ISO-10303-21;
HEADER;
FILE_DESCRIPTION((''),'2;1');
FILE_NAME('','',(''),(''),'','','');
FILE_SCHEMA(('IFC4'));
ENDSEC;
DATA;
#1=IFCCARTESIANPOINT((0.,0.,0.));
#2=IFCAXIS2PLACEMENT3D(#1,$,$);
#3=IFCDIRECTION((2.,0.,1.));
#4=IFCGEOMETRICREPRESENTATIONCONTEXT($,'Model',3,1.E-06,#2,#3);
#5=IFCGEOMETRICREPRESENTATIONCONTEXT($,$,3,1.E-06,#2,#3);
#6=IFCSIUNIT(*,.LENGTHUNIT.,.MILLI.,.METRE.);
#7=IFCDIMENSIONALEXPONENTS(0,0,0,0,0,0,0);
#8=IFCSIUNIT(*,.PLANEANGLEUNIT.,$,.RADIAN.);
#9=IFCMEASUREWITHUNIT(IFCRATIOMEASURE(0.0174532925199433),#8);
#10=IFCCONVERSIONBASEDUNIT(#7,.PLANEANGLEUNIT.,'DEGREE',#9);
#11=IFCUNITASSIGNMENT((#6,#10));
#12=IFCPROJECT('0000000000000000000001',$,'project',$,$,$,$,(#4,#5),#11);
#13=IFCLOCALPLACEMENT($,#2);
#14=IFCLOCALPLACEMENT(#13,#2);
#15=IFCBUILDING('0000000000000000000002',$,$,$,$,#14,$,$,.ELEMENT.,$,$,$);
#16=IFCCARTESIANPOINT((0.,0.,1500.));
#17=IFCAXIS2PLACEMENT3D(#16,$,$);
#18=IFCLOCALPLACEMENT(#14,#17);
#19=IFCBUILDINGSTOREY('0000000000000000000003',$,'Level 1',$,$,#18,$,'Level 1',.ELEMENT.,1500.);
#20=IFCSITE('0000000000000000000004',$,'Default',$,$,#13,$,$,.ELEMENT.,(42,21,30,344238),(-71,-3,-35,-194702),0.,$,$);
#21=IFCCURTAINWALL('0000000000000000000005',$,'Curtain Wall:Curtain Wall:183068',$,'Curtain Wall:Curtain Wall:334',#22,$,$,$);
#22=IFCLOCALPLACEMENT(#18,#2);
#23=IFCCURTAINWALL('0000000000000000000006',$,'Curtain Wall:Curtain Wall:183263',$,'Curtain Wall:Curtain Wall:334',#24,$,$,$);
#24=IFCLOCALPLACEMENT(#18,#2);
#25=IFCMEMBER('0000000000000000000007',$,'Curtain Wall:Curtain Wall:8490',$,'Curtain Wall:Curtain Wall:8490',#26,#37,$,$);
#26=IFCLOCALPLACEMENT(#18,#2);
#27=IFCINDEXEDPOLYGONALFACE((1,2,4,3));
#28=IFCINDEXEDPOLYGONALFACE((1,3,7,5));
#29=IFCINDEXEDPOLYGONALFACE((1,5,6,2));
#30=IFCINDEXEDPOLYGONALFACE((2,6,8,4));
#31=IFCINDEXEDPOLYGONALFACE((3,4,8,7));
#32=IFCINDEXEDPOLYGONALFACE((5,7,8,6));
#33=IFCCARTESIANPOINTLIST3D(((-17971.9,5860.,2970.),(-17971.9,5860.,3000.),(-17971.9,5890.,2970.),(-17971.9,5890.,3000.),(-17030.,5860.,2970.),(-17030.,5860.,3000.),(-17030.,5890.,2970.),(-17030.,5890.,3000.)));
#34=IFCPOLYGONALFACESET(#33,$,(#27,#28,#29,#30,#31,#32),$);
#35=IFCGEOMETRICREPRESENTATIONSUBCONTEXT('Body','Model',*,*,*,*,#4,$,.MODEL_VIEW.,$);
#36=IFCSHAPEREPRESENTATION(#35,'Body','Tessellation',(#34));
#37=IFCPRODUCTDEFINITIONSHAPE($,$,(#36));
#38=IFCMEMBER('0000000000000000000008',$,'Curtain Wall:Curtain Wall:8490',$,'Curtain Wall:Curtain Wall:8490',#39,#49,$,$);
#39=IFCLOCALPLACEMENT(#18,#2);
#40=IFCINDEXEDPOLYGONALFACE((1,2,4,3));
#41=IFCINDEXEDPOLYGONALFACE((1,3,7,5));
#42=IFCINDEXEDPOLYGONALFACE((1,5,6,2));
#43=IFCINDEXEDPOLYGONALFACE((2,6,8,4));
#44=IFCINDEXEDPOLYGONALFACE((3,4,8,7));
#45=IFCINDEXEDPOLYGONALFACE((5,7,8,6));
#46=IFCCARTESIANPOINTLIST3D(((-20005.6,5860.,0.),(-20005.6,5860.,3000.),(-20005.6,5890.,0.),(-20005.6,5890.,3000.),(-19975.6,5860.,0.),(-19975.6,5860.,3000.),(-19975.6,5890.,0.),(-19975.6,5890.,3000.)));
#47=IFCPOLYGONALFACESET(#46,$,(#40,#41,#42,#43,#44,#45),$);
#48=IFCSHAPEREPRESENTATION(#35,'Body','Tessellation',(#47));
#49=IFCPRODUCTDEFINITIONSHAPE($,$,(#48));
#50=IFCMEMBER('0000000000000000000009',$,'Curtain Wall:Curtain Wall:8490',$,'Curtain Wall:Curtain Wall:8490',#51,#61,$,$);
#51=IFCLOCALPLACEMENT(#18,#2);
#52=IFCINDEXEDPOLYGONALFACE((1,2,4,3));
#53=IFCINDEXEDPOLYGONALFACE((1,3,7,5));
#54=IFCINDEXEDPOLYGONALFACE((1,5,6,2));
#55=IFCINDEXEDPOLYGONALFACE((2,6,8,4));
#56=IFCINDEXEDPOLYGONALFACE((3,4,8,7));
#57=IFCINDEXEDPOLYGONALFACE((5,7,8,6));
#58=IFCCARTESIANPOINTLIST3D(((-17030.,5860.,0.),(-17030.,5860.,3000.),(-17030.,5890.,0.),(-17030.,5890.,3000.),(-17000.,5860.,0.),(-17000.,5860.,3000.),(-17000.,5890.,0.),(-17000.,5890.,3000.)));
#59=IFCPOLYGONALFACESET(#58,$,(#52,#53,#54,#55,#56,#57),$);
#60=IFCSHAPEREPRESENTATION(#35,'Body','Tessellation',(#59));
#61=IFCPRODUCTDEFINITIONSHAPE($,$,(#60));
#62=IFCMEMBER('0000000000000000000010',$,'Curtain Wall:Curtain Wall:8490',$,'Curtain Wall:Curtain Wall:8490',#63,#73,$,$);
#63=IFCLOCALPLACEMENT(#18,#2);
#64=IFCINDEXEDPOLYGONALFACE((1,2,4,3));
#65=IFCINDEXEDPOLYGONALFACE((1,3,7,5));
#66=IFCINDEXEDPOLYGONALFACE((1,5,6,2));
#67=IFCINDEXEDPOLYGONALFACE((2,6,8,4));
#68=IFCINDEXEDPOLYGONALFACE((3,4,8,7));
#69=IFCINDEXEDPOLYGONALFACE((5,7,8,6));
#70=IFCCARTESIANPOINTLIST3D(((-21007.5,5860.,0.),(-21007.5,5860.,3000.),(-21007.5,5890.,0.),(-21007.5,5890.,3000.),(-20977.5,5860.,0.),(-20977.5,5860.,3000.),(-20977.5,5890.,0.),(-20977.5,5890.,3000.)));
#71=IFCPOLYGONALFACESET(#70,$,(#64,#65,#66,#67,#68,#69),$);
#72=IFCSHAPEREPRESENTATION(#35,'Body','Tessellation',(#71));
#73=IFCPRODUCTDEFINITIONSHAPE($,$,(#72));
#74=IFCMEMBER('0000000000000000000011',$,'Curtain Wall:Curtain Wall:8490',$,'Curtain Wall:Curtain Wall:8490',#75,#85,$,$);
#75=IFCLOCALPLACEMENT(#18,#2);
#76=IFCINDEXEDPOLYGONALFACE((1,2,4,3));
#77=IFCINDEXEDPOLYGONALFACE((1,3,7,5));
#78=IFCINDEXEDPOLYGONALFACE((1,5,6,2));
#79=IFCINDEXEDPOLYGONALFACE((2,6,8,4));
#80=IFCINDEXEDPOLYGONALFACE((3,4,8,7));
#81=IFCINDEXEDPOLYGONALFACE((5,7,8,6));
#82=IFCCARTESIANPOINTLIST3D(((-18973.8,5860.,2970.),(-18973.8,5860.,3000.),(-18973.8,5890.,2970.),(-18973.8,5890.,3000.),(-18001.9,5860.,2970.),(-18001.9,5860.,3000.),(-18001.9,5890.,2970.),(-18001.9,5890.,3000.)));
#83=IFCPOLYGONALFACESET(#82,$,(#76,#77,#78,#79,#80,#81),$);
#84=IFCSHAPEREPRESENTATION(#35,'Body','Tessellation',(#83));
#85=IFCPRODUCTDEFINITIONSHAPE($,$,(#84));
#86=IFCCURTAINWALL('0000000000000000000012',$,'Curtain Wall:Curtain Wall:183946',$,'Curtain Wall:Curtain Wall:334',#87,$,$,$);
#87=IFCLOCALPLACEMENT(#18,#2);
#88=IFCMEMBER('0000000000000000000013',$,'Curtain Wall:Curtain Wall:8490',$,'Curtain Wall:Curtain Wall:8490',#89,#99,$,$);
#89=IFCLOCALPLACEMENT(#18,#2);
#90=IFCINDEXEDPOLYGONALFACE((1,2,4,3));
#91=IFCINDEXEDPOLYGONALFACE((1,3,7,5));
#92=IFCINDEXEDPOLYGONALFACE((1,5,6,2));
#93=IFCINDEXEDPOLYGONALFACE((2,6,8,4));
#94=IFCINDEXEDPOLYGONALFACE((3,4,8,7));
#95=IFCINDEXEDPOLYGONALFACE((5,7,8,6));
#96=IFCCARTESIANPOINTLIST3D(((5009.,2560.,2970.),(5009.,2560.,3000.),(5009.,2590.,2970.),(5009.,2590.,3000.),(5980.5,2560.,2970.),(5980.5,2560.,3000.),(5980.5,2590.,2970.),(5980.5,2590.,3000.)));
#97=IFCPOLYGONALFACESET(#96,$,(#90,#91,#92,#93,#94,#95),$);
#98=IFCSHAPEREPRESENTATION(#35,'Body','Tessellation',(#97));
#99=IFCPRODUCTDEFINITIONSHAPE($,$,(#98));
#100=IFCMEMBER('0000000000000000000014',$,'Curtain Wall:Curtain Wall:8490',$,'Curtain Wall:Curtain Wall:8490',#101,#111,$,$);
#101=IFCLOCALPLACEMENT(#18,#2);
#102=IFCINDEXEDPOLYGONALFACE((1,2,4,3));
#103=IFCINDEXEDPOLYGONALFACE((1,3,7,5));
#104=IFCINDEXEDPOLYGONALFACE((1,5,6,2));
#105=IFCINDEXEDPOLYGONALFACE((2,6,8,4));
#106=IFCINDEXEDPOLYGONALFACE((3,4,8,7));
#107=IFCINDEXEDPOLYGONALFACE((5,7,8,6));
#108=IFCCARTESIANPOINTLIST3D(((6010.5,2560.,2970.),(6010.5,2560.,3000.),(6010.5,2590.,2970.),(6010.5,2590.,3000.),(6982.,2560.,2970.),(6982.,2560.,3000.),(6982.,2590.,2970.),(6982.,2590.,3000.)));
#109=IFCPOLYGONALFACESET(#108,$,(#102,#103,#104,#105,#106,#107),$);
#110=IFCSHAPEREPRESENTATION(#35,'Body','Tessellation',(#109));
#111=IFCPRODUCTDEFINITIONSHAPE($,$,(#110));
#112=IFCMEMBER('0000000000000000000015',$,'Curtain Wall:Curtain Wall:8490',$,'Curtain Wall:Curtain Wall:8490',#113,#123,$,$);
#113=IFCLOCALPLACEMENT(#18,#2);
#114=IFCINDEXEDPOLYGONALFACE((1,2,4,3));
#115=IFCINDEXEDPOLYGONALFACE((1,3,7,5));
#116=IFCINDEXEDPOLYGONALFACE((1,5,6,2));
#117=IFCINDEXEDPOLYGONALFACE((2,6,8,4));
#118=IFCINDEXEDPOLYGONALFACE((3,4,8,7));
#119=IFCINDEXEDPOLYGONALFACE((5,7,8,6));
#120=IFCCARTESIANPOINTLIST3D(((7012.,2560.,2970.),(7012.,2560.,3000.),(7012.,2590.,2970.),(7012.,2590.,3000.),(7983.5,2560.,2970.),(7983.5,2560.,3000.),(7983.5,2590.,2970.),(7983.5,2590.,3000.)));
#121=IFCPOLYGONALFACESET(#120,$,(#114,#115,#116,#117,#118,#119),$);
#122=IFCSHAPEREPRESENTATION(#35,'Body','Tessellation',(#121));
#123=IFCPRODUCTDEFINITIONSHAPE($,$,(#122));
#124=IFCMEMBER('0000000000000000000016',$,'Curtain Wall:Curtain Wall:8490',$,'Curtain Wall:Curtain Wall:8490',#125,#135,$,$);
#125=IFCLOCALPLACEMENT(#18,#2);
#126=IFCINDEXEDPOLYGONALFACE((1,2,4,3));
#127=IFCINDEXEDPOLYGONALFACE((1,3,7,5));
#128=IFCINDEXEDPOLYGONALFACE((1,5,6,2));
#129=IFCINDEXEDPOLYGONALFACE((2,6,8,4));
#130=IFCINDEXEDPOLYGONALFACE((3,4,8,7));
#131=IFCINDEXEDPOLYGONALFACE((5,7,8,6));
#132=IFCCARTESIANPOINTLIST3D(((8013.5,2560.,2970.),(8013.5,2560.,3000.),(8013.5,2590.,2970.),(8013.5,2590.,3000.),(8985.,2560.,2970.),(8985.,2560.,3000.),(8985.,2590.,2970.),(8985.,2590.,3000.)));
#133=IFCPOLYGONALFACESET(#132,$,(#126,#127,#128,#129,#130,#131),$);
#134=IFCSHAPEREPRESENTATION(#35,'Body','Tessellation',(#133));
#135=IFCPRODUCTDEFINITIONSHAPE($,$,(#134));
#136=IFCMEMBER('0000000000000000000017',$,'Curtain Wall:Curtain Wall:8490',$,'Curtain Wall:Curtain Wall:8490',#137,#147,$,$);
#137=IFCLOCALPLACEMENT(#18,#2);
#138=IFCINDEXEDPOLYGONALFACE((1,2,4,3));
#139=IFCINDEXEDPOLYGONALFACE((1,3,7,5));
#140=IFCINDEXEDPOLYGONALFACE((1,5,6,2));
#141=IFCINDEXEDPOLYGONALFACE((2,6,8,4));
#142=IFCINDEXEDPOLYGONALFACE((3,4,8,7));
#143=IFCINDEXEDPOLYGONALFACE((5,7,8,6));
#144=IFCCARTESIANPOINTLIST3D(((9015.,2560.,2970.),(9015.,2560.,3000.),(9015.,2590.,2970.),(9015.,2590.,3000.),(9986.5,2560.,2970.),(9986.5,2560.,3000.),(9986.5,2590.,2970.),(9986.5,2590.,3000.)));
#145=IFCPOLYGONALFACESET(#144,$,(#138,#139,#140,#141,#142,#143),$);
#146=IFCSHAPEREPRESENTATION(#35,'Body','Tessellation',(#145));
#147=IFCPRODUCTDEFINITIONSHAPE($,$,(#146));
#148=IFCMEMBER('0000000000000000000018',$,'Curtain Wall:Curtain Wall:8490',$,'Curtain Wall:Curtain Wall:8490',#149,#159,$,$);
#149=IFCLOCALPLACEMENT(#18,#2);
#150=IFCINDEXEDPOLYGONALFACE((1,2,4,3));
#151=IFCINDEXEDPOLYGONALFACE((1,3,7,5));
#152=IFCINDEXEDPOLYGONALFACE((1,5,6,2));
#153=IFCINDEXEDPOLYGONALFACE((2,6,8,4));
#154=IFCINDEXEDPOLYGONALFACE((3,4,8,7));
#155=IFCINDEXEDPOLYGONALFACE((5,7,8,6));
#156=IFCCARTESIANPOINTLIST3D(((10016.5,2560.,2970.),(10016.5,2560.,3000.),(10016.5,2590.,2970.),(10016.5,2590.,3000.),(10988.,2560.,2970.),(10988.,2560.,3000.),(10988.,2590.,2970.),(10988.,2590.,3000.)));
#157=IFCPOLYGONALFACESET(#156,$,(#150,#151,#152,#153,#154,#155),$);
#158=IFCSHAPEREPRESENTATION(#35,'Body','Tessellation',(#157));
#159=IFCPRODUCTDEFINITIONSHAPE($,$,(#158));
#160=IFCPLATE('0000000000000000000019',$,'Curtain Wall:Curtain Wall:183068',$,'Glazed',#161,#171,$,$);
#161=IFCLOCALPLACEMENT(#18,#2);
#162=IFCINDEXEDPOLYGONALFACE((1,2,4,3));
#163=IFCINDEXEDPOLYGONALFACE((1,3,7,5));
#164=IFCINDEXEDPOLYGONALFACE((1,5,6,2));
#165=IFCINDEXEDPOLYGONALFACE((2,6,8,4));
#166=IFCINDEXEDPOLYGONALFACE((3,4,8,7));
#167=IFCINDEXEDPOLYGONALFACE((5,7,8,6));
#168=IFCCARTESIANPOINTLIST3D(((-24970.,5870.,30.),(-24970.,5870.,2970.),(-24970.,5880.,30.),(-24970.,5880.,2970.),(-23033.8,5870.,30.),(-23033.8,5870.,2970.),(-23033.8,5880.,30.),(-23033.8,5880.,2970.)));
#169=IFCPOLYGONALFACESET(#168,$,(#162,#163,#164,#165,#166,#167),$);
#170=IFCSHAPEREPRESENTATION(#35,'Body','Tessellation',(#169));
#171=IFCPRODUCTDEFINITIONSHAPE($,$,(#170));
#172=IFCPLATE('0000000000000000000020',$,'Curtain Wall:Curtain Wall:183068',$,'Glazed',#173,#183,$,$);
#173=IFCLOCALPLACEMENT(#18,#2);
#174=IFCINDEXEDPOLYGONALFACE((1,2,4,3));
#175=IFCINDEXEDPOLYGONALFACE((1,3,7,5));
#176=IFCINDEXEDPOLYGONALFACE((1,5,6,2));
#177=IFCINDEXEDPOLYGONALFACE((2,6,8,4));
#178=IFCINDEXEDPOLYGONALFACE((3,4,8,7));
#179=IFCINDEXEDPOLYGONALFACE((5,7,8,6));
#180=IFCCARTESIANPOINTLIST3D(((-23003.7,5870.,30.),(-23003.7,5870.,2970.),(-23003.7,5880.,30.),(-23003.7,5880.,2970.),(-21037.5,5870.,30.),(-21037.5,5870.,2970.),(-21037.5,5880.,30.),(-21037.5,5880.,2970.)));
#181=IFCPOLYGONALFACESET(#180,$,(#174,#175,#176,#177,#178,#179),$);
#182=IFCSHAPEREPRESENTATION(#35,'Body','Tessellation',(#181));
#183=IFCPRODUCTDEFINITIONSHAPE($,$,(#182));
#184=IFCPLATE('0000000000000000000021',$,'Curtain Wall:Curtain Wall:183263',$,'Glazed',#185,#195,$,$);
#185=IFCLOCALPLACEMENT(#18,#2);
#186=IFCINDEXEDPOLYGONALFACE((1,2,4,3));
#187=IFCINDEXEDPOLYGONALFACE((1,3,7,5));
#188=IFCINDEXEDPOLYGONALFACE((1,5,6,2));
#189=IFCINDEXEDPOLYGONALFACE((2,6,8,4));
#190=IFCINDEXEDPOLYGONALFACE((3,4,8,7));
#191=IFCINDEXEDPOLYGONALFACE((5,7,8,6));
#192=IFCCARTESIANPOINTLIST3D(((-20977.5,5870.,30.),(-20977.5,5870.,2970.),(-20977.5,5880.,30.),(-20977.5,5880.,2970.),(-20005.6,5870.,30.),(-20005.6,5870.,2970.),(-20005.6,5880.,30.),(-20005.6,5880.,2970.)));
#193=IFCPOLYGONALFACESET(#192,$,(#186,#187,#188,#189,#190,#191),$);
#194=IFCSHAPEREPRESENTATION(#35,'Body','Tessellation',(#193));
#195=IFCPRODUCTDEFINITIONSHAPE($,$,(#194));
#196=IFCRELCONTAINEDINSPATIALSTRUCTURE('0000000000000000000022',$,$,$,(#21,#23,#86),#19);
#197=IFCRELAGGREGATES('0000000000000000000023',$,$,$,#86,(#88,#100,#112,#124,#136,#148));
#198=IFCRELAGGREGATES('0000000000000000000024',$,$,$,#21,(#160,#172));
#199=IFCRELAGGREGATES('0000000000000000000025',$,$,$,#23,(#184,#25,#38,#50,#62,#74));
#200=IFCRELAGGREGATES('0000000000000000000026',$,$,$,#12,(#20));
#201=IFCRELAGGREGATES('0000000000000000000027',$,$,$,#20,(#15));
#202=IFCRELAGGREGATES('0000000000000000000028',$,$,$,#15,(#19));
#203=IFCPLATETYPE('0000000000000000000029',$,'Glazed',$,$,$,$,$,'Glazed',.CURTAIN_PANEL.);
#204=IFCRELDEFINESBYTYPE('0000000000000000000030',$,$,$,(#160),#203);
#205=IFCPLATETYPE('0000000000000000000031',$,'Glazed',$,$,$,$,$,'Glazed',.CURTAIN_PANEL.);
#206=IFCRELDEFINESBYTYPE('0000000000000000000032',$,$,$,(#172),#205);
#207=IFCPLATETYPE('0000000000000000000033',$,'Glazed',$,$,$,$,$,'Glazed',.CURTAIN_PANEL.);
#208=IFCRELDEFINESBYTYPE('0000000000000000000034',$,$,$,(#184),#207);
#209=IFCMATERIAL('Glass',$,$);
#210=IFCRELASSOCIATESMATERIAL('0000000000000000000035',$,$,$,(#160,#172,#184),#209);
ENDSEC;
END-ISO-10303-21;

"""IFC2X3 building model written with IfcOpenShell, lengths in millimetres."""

from ifc_helpers import new_model, entity, si_unit, converted_unit, direction, frame, frame_2d, origin, origin_2d_with_axis, place, context, subcontext, project, spatial, rectangle, extrude, source, transform, mapped, material, type_object, type_shapes, element, aggregate, save


model = new_model("IFC2X3")

# Units and contexts
model_context = context("Model", 3, precision=1e-06, world=origin(), true_north=direction((2.0, 0.0, 1.0)))
context_of_model = context(None, 3, precision=1e-06, world=origin(), true_north=direction((2.0, 0.0, 1.0)))
body_context = subcontext(model_context, "Body", "Model", "MODEL_VIEW")
ifc_project = project(units=[si_unit("LENGTHUNIT", "METRE", prefix="MILLI"), converted_unit("PLANEANGLEUNIT", "DEGREE", entity("IfcRatioMeasure", 0.0174532925199433), si_unit("PLANEANGLEUNIT", "RADIAN"), dimensions=[0, 0, 0, 0, 0, 0, 0])], contexts=[model_context, context_of_model])

# Site, building, storey
site_placement = place(None, origin())
site = spatial("IfcSite", under=ifc_project, at=site_placement, Name="Default", CompositionType="ELEMENT", RefLatitude=(42, 21, 30, 344238), RefLongitude=(-71, -3, -35, -194702), RefElevation=0.0)
building_placement = place(site_placement, origin())
building = spatial("IfcBuilding", under=site, at=building_placement, CompositionType="ELEMENT")
storey_placement = place(building_placement, frame((0.0, 0.0, 1500.0)))
storey = spatial("IfcBuildingStorey", under=building, at=storey_placement, Name="Level 1", LongName="Level 1", CompositionType="ELEMENT", Elevation=1500.0)

# Curtain walls, members
curtain_wall_1_placement = place(storey_placement, origin())
curtain_wall_1 = element("IfcCurtainWall", 1, at=curtain_wall_1_placement, inside=storey, Name="Curtain Wall:Curtain Wall:183068", ObjectType="Curtain Wall:Curtain Wall:334")
curtain_wall_2_placement = place(storey_placement, origin())
curtain_wall_2 = element("IfcCurtainWall", 2, at=curtain_wall_2_placement, inside=storey, Name="Curtain Wall:Curtain Wall:183263", ObjectType="Curtain Wall:Curtain Wall:334")
member_1_placement = place(storey_placement, origin())
member_1 = element("IfcMember", 3, at=member_1_placement, Name="Curtain Wall:Curtain Wall:8490", ObjectType="Curtain Wall:Curtain Wall:8490", context=body_context, shape_type="SweptSolid", body=[
    extrude(rectangle(XDim=941.9, YDim=30.0, at=frame_2d((0.0, 0.0), x_axis=(1.0, 0.0))), frame((-17500.9, 5875.0, 2970.0), z_axis=(0.0, 0.0, 1.0), x_axis=(-1.0, 0.0, 0.0)), (0.0, 0.0, 1.0), 30.0),
])
member_2_placement = place(storey_placement, origin())
member_2 = element("IfcMember", 4, at=member_2_placement, Name="Curtain Wall:Curtain Wall:8490", ObjectType="Curtain Wall:Curtain Wall:8490", context=body_context, shape_type="SweptSolid", body=[
    extrude(rectangle(XDim=30.0, YDim=30.0, at=frame_2d((0.0, 0.0), x_axis=(1.0, 0.0))), frame((-19990.6, 5875.0, 0.0), z_axis=(0.0, 0.0, 1.0), x_axis=(0.0, 1.0, 0.0)), (0.0, 0.0, 1.0), 3000.0),
])
member_3_placement = place(storey_placement, origin())
member_3 = element("IfcMember", 5, at=member_3_placement, Name="Curtain Wall:Curtain Wall:8490", ObjectType="Curtain Wall:Curtain Wall:8490", context=body_context, shape_type="SweptSolid", body=[
    extrude(rectangle(XDim=30.0, YDim=30.0, at=frame_2d((0.0, 0.0), x_axis=(1.0, 0.0))), frame((-17015.0, 5875.0, 0.0), z_axis=(0.0, 0.0, 1.0), x_axis=(0.0, 1.0, 0.0)), (0.0, 0.0, 1.0), 3000.0),
])
member_4_placement = place(storey_placement, origin())
member_4 = element("IfcMember", 6, at=member_4_placement, Name="Curtain Wall:Curtain Wall:8490", ObjectType="Curtain Wall:Curtain Wall:8490", context=body_context, shape_type="SweptSolid", body=[
    extrude(rectangle(XDim=30.0, YDim=30.0, at=origin_2d_with_axis()), frame((-20992.5, 5875.0, 0.0)), (0.0, 0.0, 1.0), 3000.0),
])
member_5_placement = place(storey_placement, origin())
member_5 = element("IfcMember", 7, at=member_5_placement, Name="Curtain Wall:Curtain Wall:8490", ObjectType="Curtain Wall:Curtain Wall:8490", context=body_context, shape_type="SweptSolid", body=[
    extrude(rectangle(XDim=971.9, YDim=30.0, at=frame_2d((0.0, 0.0), x_axis=(1.0, 0.0))), frame((-18487.8, 5875.0, 2970.0), z_axis=(0.0, 0.0, 1.0), x_axis=(-1.0, 0.0, 0.0)), (0.0, 0.0, 1.0), 30.0),
])
curtain_wall_3_placement = place(storey_placement, origin())
curtain_wall_3 = element("IfcCurtainWall", 8, at=curtain_wall_3_placement, inside=storey, Name="Curtain Wall:Curtain Wall:183946", ObjectType="Curtain Wall:Curtain Wall:334")
member_6_placement = place(storey_placement, origin())
member_6 = element("IfcMember", 9, at=member_6_placement, Name="Curtain Wall:Curtain Wall:8490", ObjectType="Curtain Wall:Curtain Wall:8490", context=body_context, shape_type="SweptSolid", body=[
    extrude(rectangle(XDim=971.5, YDim=30.0, at=frame_2d((0.0, 0.0), x_axis=(1.0, 0.0))), frame((5494.8, 2575.0, 2970.0)), (0.0, 0.0, 1.0), 30.0),
])
member_7_placement = place(storey_placement, origin())
member_7 = element("IfcMember", 10, at=member_7_placement, Name="Curtain Wall:Curtain Wall:8490", ObjectType="Curtain Wall:Curtain Wall:8490", context=body_context, shape_type="SweptSolid", body=[
    extrude(rectangle(XDim=971.5, YDim=30.0, at=frame_2d((0.0, 0.0), x_axis=(1.0, 0.0))), frame((6496.2, 2575.0, 2970.0)), (0.0, 0.0, 1.0), 30.0),
])
member_8_placement = place(storey_placement, origin())
member_8 = element("IfcMember", 11, at=member_8_placement, Name="Curtain Wall:Curtain Wall:8490", ObjectType="Curtain Wall:Curtain Wall:8490", context=body_context, shape_type="SweptSolid", body=[
    extrude(rectangle(XDim=971.5, YDim=30.0, at=frame_2d((0.0, 0.0), x_axis=(1.0, 0.0))), frame((7497.8, 2575.0, 2970.0)), (0.0, 0.0, 1.0), 30.0),
])
member_9_placement = place(storey_placement, origin())
member_9 = element("IfcMember", 12, at=member_9_placement, Name="Curtain Wall:Curtain Wall:8490", ObjectType="Curtain Wall:Curtain Wall:8490", context=body_context, shape_type="SweptSolid", body=[
    extrude(rectangle(XDim=971.5, YDim=30.0, at=frame_2d((0.0, 0.0), x_axis=(1.0, 0.0))), frame((8499.2, 2575.0, 2970.0)), (0.0, 0.0, 1.0), 30.0),
])
member_10_placement = place(storey_placement, origin())
member_10 = element("IfcMember", 13, at=member_10_placement, Name="Curtain Wall:Curtain Wall:8490", ObjectType="Curtain Wall:Curtain Wall:8490", context=body_context, shape_type="SweptSolid", body=[
    extrude(rectangle(XDim=971.5, YDim=30.0, at=frame_2d((0.0, 0.0), x_axis=(1.0, 0.0))), frame((9500.8, 2575.0, 2970.0)), (0.0, 0.0, 1.0), 30.0),
])
member_11_placement = place(storey_placement, origin())
member_11 = element("IfcMember", 14, at=member_11_placement, Name="Curtain Wall:Curtain Wall:8490", ObjectType="Curtain Wall:Curtain Wall:8490", context=body_context, shape_type="SweptSolid", body=[
    extrude(rectangle(XDim=971.5, YDim=30.0, at=frame_2d((0.0, 0.0), x_axis=(1.0, 0.0))), frame((10502.2, 2575.0, 2970.0)), (0.0, 0.0, 1.0), 30.0),
])
aggregate(curtain_wall_3, [member_6, member_7, member_8, member_9, member_10, member_11])

# Plates
ifc_material_1 = material(Name="Glass")
plate_type_1 = type_object("IfcPlateType", Name="Glazed", ElementType="Glazed", PredefinedType="CURTAIN_PANEL")
shared_shape_1 = source(origin(), body_context, "Body", "SweptSolid", [
    extrude(rectangle(XDim=10.0, YDim=1936.2, at=origin_2d_with_axis()), frame((0.0, 0.0, 0.0), z_axis=(0.0, 0.0, 1.0), x_axis=(0.0, 1.0, 0.0)), (0.0, 0.0, 1.0), 2940.0),
])
type_shapes(plate_type_1, [shared_shape_1])
plate_1_placement = place(storey_placement, frame((-24001.9, 5875.0, 30.0)))
plate_1 = element("IfcPlate", 15, at=plate_1_placement, type_object=plate_type_1, material=ifc_material_1, Name="Curtain Wall:Curtain Wall:183068", ObjectType="Glazed", context=body_context, shape_type="MappedRepresentation", body=[
    mapped(shared_shape_1, transform((0.0, 0.0, 0.0), scale=1.0)),
])
plate_type_2 = type_object("IfcPlateType", Name="Glazed", ElementType="Glazed", PredefinedType="CURTAIN_PANEL")
shared_shape_2 = source(origin(), body_context, "Body", "SweptSolid", [
    extrude(rectangle(XDim=10.0, YDim=1966.2, at=origin_2d_with_axis()), frame((0.0, 0.0, 0.0), z_axis=(0.0, 0.0, 1.0), x_axis=(0.0, 1.0, 0.0)), (0.0, 0.0, 1.0), 2940.0),
])
type_shapes(plate_type_2, [shared_shape_2])
plate_2_placement = place(storey_placement, frame((-22020.6, 5875.0, 30.0)))
plate_2 = element("IfcPlate", 16, at=plate_2_placement, type_object=plate_type_2, material=ifc_material_1, Name="Curtain Wall:Curtain Wall:183068", ObjectType="Glazed", context=body_context, shape_type="MappedRepresentation", body=[
    mapped(shared_shape_2, transform((0.0, 0.0, 0.0), scale=1.0)),
])
aggregate(curtain_wall_1, [plate_1, plate_2])
plate_type_3 = type_object("IfcPlateType", Name="Glazed", ElementType="Glazed", PredefinedType="CURTAIN_PANEL")
shared_shape_3 = source(origin(), body_context, "Body", "SweptSolid", [
    extrude(rectangle(XDim=10.0, YDim=971.9, at=origin_2d_with_axis()), frame((0.0, 0.0, 0.0), z_axis=(0.0, 0.0, 1.0), x_axis=(0.0, 1.0, 0.0)), (0.0, 0.0, 1.0), 2940.0),
])
type_shapes(plate_type_3, [shared_shape_3])
plate_3_placement = place(storey_placement, frame((-20491.6, 5875.0, 30.0)))
plate_3 = element("IfcPlate", 17, at=plate_3_placement, type_object=plate_type_3, material=ifc_material_1, Name="Curtain Wall:Curtain Wall:183263", ObjectType="Glazed", context=body_context, shape_type="MappedRepresentation", body=[
    mapped(shared_shape_3, transform((0.0, 0.0, 0.0), scale=1.0)),
])
aggregate(curtain_wall_2, [plate_3, member_1, member_2, member_3, member_4, member_5])

save(model, "model.ifc")
